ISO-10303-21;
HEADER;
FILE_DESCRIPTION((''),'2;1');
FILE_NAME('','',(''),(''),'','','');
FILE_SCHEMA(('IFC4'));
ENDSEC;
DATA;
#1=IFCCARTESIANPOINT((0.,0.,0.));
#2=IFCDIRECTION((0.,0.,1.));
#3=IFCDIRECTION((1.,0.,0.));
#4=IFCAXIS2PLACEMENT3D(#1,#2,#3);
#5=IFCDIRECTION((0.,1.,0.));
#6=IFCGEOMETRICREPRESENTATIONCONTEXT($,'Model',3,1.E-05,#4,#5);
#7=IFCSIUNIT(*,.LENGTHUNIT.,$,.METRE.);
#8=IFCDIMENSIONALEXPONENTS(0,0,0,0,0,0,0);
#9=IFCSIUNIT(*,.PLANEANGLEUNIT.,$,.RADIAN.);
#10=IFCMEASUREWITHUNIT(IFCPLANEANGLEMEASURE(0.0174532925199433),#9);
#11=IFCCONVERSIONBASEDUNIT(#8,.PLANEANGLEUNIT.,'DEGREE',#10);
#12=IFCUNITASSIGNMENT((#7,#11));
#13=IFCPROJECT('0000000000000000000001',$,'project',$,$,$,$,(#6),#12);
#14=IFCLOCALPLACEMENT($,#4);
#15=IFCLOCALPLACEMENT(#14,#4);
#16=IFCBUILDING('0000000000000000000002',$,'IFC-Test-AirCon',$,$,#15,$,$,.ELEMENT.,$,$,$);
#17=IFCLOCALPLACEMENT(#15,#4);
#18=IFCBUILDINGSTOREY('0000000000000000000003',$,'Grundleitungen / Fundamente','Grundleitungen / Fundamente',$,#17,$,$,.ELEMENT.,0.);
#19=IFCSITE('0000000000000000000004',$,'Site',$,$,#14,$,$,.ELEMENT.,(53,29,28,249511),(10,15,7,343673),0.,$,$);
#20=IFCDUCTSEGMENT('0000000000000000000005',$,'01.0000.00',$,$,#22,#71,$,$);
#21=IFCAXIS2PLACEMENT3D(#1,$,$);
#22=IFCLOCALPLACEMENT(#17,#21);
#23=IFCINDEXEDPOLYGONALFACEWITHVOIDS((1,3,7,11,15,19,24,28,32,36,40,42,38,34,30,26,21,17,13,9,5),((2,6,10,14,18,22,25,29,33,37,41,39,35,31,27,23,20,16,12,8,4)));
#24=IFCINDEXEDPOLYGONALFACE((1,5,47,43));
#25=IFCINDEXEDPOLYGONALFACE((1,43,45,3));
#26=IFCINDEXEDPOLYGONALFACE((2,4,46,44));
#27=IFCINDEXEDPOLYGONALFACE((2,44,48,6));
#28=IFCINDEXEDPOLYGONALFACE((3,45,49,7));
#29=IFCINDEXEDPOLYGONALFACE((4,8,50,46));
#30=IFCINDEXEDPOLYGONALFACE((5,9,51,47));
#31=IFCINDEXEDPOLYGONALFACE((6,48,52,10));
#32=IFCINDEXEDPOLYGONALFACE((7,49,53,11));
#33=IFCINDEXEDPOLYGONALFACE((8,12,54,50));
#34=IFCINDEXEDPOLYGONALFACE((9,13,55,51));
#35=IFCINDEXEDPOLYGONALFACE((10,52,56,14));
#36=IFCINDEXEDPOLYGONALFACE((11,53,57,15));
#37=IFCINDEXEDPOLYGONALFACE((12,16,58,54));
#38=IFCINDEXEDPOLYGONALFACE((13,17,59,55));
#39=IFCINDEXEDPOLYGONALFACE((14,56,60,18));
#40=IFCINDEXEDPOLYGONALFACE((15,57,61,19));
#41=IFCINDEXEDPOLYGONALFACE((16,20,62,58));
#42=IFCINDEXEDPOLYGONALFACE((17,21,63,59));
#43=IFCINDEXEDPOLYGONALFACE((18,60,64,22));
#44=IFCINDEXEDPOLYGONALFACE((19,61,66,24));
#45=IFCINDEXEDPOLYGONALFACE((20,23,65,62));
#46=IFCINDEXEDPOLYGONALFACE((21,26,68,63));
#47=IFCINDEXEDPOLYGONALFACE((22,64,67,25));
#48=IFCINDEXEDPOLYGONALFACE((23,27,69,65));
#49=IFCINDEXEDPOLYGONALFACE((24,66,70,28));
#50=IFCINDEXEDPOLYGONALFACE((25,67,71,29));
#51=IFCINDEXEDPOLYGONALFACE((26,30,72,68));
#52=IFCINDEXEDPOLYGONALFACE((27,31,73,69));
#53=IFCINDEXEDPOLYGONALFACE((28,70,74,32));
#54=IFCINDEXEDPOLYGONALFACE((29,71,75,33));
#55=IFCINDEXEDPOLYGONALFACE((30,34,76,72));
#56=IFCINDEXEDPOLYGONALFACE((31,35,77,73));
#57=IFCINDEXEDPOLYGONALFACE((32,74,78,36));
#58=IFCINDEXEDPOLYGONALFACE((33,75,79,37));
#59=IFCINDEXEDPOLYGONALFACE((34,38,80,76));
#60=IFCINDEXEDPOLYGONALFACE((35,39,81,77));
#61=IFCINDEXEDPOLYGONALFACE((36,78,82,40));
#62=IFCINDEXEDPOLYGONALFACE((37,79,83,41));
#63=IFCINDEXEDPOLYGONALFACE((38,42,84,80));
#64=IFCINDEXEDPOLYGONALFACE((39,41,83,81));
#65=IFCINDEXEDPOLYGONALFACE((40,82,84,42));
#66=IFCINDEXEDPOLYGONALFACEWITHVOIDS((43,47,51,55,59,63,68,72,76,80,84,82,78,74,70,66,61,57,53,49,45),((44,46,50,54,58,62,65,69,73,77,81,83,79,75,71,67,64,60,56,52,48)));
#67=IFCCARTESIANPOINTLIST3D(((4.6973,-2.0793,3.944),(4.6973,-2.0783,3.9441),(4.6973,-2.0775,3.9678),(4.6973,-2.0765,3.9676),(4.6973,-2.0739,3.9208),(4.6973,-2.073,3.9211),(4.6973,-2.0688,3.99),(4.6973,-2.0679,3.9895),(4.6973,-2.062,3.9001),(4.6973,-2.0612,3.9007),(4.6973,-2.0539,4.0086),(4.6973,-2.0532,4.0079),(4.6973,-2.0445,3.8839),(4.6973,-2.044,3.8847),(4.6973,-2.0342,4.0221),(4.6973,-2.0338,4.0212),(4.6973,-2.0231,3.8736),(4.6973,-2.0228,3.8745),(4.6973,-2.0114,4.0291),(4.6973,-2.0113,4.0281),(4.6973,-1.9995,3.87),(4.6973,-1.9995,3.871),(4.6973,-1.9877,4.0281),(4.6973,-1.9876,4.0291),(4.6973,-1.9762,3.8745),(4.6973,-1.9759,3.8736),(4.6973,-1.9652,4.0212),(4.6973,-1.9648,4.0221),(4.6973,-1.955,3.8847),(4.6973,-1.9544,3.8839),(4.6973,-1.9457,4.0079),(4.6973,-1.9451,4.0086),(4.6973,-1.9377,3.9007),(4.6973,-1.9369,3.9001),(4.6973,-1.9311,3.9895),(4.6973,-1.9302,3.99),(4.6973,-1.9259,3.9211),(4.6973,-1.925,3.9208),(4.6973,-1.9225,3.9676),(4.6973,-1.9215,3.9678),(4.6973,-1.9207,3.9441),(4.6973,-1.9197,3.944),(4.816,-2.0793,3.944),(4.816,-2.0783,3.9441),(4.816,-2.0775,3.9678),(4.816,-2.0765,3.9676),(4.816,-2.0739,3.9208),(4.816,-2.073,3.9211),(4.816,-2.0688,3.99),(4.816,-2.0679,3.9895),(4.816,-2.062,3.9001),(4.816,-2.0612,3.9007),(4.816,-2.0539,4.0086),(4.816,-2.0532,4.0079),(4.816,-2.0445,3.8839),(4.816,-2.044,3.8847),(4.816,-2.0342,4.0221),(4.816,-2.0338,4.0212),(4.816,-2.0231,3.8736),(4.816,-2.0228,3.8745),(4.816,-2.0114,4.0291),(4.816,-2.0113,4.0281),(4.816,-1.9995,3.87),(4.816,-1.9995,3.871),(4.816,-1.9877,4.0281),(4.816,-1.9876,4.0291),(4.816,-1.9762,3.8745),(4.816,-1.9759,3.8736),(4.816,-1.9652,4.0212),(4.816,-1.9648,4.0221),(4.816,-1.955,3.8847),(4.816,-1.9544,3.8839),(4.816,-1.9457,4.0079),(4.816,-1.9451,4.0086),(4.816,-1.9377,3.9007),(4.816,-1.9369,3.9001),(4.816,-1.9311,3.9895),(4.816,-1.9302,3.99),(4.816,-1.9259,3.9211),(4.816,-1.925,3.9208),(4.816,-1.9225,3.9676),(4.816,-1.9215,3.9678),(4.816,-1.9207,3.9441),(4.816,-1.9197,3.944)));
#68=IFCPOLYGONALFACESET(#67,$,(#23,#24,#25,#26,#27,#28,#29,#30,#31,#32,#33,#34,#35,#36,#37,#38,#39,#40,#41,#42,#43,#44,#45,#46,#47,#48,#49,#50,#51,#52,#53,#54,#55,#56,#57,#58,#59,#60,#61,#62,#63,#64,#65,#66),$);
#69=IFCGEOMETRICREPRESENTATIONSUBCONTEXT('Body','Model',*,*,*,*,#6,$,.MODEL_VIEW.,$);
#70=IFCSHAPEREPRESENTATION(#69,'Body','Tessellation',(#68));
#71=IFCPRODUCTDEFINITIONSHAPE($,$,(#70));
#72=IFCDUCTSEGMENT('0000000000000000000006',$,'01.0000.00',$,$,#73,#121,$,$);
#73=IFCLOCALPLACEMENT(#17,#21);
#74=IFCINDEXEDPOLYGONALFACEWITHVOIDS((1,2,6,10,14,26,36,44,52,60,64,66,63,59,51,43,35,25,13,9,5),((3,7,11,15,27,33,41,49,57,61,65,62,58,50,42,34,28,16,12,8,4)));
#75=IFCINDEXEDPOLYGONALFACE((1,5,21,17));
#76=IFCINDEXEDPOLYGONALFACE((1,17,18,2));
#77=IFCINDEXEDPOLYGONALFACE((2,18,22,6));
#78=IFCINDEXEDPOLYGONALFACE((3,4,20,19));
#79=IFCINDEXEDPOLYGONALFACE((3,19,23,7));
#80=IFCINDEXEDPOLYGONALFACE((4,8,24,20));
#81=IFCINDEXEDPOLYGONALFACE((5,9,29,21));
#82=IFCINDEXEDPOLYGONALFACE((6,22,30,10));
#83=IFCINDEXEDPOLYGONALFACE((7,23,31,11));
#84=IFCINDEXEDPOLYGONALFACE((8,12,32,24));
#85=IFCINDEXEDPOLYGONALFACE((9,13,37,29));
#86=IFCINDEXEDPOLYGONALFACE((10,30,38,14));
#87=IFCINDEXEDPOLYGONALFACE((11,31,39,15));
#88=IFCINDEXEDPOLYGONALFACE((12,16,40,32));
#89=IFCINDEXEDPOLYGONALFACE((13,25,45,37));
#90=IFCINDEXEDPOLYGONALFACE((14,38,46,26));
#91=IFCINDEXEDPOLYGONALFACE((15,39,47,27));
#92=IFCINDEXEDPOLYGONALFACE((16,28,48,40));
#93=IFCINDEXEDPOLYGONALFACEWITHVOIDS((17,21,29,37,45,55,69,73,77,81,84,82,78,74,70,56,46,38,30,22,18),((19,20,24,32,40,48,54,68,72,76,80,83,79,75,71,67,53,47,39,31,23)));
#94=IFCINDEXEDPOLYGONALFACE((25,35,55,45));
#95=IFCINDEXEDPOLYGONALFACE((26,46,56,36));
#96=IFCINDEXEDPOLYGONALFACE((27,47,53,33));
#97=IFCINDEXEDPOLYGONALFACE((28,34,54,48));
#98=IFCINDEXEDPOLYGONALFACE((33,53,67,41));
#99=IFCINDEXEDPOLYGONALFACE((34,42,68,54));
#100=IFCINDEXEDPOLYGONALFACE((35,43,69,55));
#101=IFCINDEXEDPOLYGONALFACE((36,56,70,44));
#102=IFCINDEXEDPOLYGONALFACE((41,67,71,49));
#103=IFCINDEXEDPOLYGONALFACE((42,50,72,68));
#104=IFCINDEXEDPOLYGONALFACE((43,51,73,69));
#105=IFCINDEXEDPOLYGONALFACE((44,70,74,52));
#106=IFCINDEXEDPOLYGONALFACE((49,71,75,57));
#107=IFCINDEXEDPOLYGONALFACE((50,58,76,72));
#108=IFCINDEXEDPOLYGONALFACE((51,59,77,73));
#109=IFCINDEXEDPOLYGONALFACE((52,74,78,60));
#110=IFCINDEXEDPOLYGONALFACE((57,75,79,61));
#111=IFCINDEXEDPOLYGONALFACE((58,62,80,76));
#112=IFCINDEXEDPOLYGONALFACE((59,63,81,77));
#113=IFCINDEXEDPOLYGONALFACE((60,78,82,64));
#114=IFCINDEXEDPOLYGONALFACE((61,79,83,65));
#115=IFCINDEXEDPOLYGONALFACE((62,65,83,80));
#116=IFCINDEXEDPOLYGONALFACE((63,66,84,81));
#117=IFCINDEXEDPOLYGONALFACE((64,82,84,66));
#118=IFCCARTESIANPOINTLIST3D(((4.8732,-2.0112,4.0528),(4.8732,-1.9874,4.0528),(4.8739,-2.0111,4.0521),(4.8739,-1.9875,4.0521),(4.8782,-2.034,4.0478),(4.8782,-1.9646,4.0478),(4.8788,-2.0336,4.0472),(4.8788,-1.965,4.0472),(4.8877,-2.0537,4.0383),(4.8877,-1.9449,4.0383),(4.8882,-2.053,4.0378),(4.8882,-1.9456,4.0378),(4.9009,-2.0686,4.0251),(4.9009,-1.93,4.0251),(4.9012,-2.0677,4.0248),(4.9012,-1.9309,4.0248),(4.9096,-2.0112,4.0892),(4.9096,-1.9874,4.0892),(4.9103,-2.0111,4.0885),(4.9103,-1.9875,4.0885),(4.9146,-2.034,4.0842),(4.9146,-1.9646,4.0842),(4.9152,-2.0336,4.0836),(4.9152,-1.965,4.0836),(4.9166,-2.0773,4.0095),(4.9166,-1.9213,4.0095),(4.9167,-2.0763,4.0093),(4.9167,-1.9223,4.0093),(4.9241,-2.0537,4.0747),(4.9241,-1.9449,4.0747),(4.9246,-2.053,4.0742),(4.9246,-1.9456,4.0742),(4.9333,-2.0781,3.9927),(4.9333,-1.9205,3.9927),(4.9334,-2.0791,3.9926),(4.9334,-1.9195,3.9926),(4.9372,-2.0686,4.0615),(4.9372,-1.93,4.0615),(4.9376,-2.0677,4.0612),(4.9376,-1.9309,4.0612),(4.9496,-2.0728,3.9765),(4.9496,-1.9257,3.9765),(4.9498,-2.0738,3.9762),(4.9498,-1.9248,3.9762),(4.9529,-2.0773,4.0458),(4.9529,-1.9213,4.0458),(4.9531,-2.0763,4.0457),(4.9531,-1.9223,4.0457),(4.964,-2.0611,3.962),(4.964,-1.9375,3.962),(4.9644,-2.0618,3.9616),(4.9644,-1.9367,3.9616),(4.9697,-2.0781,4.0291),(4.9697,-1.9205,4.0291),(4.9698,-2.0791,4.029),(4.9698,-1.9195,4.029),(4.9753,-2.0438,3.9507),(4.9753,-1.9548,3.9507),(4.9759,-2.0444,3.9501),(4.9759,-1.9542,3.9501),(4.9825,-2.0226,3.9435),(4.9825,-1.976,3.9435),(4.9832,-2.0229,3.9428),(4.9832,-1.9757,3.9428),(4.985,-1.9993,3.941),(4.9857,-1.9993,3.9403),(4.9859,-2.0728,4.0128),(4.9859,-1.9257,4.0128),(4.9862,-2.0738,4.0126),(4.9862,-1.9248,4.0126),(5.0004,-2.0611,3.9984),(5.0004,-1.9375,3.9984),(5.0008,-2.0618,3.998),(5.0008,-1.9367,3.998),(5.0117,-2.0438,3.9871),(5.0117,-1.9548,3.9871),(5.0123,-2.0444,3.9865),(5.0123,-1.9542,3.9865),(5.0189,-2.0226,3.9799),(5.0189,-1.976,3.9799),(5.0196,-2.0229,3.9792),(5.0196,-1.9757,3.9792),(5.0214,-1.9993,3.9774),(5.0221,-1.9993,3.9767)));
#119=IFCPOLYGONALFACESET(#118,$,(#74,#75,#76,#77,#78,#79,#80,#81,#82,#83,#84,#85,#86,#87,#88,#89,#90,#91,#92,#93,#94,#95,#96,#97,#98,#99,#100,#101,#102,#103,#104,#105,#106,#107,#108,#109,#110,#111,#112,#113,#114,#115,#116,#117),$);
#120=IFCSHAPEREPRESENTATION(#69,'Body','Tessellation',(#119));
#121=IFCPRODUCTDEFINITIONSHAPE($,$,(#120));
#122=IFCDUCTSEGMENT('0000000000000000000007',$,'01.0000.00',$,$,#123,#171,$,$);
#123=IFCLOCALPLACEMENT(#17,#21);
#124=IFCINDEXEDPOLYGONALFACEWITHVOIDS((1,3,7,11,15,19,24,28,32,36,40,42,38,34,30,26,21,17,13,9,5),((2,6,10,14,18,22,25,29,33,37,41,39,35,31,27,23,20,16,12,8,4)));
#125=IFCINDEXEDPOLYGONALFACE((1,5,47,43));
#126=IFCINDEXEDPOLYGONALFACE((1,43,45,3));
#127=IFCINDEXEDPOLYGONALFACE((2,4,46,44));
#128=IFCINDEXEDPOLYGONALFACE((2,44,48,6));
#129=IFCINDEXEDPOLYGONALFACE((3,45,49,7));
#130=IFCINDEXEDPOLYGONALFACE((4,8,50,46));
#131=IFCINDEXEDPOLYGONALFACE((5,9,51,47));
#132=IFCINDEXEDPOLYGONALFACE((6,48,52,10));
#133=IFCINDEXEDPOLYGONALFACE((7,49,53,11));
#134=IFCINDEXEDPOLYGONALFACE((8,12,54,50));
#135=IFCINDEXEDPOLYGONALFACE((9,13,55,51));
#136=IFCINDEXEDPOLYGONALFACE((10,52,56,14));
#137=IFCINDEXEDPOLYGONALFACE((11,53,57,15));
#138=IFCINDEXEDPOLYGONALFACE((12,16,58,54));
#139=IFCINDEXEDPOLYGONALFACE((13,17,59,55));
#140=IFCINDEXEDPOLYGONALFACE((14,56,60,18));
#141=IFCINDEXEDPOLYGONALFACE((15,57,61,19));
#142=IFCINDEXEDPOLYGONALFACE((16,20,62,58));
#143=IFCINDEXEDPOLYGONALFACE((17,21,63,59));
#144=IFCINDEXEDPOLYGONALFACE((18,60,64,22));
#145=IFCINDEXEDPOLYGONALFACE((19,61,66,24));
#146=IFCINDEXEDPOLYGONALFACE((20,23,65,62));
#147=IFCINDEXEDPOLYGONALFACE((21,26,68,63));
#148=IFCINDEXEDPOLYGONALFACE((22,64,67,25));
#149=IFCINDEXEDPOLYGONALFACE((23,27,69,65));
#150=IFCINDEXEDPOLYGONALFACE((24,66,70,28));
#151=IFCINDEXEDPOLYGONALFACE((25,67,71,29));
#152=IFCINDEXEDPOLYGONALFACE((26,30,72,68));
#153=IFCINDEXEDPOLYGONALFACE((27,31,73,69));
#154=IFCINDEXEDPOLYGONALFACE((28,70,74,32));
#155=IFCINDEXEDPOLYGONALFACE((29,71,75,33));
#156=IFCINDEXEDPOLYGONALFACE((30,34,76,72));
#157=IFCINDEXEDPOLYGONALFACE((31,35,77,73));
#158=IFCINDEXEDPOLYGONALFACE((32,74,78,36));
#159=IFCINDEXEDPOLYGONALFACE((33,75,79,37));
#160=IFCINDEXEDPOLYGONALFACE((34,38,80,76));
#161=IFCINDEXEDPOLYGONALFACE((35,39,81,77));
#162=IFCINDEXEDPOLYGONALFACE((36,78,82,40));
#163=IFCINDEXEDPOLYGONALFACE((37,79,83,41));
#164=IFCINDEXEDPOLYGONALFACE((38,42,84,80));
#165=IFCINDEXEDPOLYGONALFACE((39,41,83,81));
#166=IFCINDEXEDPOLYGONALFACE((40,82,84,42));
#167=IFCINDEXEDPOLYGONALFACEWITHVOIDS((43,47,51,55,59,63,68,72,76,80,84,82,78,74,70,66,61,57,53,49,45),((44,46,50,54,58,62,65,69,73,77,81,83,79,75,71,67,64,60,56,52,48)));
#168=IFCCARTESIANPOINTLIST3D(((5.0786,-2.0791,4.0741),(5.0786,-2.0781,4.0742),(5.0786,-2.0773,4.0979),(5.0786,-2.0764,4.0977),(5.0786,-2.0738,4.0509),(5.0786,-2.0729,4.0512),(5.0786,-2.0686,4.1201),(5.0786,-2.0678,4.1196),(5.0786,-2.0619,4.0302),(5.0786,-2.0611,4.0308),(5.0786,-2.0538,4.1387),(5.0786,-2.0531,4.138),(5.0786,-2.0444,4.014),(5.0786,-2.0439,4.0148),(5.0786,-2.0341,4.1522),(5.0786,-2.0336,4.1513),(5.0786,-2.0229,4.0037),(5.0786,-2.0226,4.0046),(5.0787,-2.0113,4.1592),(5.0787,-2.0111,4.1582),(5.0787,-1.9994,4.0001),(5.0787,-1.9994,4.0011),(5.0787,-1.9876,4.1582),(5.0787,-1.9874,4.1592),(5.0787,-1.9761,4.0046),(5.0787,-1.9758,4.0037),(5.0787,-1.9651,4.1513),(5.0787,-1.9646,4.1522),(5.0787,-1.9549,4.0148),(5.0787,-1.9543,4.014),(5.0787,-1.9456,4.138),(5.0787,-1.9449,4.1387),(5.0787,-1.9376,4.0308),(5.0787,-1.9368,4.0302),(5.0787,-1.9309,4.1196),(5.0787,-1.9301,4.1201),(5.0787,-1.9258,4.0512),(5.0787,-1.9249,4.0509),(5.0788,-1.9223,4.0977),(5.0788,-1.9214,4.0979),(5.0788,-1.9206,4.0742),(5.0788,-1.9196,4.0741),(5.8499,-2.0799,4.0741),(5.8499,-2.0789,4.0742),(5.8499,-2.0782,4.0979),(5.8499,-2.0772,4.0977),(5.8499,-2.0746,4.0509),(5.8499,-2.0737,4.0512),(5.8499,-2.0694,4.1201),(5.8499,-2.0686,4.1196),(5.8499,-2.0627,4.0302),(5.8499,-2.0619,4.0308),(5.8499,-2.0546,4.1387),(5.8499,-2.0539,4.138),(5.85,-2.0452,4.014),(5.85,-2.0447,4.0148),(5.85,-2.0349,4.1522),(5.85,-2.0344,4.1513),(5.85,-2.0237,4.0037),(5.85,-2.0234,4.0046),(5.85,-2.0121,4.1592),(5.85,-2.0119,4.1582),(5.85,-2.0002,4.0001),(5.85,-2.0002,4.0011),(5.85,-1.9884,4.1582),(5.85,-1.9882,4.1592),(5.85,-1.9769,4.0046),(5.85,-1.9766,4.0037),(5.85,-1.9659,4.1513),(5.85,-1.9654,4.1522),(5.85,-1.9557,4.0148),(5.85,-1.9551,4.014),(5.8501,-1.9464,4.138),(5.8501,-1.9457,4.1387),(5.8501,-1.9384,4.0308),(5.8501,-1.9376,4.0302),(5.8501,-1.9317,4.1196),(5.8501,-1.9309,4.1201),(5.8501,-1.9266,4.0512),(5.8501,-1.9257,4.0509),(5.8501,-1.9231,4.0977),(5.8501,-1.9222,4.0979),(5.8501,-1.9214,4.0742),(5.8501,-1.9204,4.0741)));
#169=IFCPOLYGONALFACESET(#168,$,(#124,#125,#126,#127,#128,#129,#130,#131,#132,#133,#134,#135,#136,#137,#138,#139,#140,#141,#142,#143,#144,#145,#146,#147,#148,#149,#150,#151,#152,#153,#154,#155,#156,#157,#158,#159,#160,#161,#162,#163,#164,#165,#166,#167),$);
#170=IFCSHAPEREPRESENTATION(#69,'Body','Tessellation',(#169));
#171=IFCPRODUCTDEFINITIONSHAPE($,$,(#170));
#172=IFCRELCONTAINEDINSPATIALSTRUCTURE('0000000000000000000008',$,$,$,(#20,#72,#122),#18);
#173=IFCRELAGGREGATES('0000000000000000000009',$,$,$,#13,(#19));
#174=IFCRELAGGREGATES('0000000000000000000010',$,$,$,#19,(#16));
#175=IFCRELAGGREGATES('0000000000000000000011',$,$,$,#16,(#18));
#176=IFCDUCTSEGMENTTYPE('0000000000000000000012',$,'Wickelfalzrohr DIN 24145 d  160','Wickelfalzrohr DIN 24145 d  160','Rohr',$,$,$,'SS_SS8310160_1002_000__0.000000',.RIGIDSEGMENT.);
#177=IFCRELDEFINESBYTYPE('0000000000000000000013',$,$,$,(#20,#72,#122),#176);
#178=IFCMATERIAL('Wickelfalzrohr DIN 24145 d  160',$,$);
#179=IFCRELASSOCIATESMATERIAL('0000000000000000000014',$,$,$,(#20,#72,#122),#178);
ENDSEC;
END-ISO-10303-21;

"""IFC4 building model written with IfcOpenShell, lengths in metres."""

from ifc_helpers import new_model, entity, si_unit, converted_unit, direction, frame, origin_with_axes, origin_2d_with_axis, place, context, subcontext, project, spatial, hollow_circle, extrude, material, type_object, element, save


model = new_model("IFC4")

# Units and contexts
model_context = context("Model", 3, precision=1e-05, world=origin_with_axes(), true_north=direction((0.0, 1.0, 0.0)))
body_context = subcontext(model_context, "Body", "Model", "MODEL_VIEW")
ifc_project = project(units=[si_unit("LENGTHUNIT", "METRE"), converted_unit("PLANEANGLEUNIT", "DEGREE", entity("IfcPlaneAngleMeasure", 0.0174532925199433), si_unit("PLANEANGLEUNIT", "RADIAN"), dimensions=[0, 0, 0, 0, 0, 0, 0])], contexts=[model_context])

# Site, building, storey
site_placement = place(None, origin_with_axes())
site = spatial("IfcSite", under=ifc_project, at=site_placement, Name="Site", CompositionType="ELEMENT", RefLatitude=(53, 29, 28, 249511), RefLongitude=(10, 15, 7, 343673), RefElevation=0.0)
building_placement = place(site_placement, origin_with_axes())
building = spatial("IfcBuilding", under=site, at=building_placement, Name="IFC-Test-AirCon", CompositionType="ELEMENT")
storey_placement = place(building_placement, origin_with_axes())
storey = spatial("IfcBuildingStorey", under=building, at=storey_placement, Name="Grundleitungen / Fundamente", Description="Grundleitungen / Fundamente", CompositionType="ELEMENT", Elevation=0.0)

# Duct segments
ifc_material_1 = material(Name="Wickelfalzrohr DIN 24145 d  160")
duct_segment_type_1 = type_object("IfcDuctSegmentType", Name="Wickelfalzrohr DIN 24145 d  160", Description="Wickelfalzrohr DIN 24145 d  160", ApplicableOccurrence="Rohr", ElementType="SS_SS8310160_1002_000__0.000000", PredefinedType="RIGIDSEGMENT")
duct_segment_1_placement = place(storey_placement, frame((4.6973, -1.9995, 3.95), z_axis=(0.0, 0.0, 1.0), x_axis=(1.0, 0.0, 0.0)))
element("IfcDuctSegment", 1, at=duct_segment_1_placement, inside=storey, type_object=duct_segment_type_1, material=ifc_material_1, Name="01.0000.00", context=body_context, shape_type="SweptSolid", body=[
    extrude(hollow_circle(Radius=0.08, WallThickness=0.001, at=origin_2d_with_axis()), frame((0.0, 0.0, 0.0), z_axis=(1.0, 0.0, 0.0), x_axis=(0.0, 0.0, -1.0)), (0.0, 0.0, 1.0), 0.1187),
])
duct_segment_2_placement = place(storey_placement, frame((4.9292, -1.9993, 3.9969), z_axis=(-0.707106, 0.0, 0.707107), x_axis=(0.707107, 0.0, 0.707106)))
element("IfcDuctSegment", 2, at=duct_segment_2_placement, inside=storey, type_object=duct_segment_type_1, material=ifc_material_1, Name="01.0000.00", context=body_context, shape_type="SweptSolid", body=[
    extrude(hollow_circle(Radius=0.08, WallThickness=0.001, at=origin_2d_with_axis()), frame((0.0, 0.0, 0.0), z_axis=(1.0, 0.0, 0.0), x_axis=(0.0, 0.0, -1.0)), (0.0, 0.0, 1.0), 0.0514),
])
duct_segment_3_placement = place(storey_placement, frame((5.0787, -1.9994, 4.0801), z_axis=(0.0, 0.0, 1.0), x_axis=(0.999999, -0.001044, 0.0)))
element("IfcDuctSegment", 3, at=duct_segment_3_placement, inside=storey, type_object=duct_segment_type_1, material=ifc_material_1, Name="01.0000.00", context=body_context, shape_type="SweptSolid", body=[
    extrude(hollow_circle(Radius=0.08, WallThickness=0.001, at=origin_2d_with_axis()), frame((0.0, 0.0, 0.0), z_axis=(1.0, 0.0, 0.0), x_axis=(0.0, 0.0, -1.0)), (0.0, 0.0, 1.0), 0.7713),
])

save(model, "model.ifc")
